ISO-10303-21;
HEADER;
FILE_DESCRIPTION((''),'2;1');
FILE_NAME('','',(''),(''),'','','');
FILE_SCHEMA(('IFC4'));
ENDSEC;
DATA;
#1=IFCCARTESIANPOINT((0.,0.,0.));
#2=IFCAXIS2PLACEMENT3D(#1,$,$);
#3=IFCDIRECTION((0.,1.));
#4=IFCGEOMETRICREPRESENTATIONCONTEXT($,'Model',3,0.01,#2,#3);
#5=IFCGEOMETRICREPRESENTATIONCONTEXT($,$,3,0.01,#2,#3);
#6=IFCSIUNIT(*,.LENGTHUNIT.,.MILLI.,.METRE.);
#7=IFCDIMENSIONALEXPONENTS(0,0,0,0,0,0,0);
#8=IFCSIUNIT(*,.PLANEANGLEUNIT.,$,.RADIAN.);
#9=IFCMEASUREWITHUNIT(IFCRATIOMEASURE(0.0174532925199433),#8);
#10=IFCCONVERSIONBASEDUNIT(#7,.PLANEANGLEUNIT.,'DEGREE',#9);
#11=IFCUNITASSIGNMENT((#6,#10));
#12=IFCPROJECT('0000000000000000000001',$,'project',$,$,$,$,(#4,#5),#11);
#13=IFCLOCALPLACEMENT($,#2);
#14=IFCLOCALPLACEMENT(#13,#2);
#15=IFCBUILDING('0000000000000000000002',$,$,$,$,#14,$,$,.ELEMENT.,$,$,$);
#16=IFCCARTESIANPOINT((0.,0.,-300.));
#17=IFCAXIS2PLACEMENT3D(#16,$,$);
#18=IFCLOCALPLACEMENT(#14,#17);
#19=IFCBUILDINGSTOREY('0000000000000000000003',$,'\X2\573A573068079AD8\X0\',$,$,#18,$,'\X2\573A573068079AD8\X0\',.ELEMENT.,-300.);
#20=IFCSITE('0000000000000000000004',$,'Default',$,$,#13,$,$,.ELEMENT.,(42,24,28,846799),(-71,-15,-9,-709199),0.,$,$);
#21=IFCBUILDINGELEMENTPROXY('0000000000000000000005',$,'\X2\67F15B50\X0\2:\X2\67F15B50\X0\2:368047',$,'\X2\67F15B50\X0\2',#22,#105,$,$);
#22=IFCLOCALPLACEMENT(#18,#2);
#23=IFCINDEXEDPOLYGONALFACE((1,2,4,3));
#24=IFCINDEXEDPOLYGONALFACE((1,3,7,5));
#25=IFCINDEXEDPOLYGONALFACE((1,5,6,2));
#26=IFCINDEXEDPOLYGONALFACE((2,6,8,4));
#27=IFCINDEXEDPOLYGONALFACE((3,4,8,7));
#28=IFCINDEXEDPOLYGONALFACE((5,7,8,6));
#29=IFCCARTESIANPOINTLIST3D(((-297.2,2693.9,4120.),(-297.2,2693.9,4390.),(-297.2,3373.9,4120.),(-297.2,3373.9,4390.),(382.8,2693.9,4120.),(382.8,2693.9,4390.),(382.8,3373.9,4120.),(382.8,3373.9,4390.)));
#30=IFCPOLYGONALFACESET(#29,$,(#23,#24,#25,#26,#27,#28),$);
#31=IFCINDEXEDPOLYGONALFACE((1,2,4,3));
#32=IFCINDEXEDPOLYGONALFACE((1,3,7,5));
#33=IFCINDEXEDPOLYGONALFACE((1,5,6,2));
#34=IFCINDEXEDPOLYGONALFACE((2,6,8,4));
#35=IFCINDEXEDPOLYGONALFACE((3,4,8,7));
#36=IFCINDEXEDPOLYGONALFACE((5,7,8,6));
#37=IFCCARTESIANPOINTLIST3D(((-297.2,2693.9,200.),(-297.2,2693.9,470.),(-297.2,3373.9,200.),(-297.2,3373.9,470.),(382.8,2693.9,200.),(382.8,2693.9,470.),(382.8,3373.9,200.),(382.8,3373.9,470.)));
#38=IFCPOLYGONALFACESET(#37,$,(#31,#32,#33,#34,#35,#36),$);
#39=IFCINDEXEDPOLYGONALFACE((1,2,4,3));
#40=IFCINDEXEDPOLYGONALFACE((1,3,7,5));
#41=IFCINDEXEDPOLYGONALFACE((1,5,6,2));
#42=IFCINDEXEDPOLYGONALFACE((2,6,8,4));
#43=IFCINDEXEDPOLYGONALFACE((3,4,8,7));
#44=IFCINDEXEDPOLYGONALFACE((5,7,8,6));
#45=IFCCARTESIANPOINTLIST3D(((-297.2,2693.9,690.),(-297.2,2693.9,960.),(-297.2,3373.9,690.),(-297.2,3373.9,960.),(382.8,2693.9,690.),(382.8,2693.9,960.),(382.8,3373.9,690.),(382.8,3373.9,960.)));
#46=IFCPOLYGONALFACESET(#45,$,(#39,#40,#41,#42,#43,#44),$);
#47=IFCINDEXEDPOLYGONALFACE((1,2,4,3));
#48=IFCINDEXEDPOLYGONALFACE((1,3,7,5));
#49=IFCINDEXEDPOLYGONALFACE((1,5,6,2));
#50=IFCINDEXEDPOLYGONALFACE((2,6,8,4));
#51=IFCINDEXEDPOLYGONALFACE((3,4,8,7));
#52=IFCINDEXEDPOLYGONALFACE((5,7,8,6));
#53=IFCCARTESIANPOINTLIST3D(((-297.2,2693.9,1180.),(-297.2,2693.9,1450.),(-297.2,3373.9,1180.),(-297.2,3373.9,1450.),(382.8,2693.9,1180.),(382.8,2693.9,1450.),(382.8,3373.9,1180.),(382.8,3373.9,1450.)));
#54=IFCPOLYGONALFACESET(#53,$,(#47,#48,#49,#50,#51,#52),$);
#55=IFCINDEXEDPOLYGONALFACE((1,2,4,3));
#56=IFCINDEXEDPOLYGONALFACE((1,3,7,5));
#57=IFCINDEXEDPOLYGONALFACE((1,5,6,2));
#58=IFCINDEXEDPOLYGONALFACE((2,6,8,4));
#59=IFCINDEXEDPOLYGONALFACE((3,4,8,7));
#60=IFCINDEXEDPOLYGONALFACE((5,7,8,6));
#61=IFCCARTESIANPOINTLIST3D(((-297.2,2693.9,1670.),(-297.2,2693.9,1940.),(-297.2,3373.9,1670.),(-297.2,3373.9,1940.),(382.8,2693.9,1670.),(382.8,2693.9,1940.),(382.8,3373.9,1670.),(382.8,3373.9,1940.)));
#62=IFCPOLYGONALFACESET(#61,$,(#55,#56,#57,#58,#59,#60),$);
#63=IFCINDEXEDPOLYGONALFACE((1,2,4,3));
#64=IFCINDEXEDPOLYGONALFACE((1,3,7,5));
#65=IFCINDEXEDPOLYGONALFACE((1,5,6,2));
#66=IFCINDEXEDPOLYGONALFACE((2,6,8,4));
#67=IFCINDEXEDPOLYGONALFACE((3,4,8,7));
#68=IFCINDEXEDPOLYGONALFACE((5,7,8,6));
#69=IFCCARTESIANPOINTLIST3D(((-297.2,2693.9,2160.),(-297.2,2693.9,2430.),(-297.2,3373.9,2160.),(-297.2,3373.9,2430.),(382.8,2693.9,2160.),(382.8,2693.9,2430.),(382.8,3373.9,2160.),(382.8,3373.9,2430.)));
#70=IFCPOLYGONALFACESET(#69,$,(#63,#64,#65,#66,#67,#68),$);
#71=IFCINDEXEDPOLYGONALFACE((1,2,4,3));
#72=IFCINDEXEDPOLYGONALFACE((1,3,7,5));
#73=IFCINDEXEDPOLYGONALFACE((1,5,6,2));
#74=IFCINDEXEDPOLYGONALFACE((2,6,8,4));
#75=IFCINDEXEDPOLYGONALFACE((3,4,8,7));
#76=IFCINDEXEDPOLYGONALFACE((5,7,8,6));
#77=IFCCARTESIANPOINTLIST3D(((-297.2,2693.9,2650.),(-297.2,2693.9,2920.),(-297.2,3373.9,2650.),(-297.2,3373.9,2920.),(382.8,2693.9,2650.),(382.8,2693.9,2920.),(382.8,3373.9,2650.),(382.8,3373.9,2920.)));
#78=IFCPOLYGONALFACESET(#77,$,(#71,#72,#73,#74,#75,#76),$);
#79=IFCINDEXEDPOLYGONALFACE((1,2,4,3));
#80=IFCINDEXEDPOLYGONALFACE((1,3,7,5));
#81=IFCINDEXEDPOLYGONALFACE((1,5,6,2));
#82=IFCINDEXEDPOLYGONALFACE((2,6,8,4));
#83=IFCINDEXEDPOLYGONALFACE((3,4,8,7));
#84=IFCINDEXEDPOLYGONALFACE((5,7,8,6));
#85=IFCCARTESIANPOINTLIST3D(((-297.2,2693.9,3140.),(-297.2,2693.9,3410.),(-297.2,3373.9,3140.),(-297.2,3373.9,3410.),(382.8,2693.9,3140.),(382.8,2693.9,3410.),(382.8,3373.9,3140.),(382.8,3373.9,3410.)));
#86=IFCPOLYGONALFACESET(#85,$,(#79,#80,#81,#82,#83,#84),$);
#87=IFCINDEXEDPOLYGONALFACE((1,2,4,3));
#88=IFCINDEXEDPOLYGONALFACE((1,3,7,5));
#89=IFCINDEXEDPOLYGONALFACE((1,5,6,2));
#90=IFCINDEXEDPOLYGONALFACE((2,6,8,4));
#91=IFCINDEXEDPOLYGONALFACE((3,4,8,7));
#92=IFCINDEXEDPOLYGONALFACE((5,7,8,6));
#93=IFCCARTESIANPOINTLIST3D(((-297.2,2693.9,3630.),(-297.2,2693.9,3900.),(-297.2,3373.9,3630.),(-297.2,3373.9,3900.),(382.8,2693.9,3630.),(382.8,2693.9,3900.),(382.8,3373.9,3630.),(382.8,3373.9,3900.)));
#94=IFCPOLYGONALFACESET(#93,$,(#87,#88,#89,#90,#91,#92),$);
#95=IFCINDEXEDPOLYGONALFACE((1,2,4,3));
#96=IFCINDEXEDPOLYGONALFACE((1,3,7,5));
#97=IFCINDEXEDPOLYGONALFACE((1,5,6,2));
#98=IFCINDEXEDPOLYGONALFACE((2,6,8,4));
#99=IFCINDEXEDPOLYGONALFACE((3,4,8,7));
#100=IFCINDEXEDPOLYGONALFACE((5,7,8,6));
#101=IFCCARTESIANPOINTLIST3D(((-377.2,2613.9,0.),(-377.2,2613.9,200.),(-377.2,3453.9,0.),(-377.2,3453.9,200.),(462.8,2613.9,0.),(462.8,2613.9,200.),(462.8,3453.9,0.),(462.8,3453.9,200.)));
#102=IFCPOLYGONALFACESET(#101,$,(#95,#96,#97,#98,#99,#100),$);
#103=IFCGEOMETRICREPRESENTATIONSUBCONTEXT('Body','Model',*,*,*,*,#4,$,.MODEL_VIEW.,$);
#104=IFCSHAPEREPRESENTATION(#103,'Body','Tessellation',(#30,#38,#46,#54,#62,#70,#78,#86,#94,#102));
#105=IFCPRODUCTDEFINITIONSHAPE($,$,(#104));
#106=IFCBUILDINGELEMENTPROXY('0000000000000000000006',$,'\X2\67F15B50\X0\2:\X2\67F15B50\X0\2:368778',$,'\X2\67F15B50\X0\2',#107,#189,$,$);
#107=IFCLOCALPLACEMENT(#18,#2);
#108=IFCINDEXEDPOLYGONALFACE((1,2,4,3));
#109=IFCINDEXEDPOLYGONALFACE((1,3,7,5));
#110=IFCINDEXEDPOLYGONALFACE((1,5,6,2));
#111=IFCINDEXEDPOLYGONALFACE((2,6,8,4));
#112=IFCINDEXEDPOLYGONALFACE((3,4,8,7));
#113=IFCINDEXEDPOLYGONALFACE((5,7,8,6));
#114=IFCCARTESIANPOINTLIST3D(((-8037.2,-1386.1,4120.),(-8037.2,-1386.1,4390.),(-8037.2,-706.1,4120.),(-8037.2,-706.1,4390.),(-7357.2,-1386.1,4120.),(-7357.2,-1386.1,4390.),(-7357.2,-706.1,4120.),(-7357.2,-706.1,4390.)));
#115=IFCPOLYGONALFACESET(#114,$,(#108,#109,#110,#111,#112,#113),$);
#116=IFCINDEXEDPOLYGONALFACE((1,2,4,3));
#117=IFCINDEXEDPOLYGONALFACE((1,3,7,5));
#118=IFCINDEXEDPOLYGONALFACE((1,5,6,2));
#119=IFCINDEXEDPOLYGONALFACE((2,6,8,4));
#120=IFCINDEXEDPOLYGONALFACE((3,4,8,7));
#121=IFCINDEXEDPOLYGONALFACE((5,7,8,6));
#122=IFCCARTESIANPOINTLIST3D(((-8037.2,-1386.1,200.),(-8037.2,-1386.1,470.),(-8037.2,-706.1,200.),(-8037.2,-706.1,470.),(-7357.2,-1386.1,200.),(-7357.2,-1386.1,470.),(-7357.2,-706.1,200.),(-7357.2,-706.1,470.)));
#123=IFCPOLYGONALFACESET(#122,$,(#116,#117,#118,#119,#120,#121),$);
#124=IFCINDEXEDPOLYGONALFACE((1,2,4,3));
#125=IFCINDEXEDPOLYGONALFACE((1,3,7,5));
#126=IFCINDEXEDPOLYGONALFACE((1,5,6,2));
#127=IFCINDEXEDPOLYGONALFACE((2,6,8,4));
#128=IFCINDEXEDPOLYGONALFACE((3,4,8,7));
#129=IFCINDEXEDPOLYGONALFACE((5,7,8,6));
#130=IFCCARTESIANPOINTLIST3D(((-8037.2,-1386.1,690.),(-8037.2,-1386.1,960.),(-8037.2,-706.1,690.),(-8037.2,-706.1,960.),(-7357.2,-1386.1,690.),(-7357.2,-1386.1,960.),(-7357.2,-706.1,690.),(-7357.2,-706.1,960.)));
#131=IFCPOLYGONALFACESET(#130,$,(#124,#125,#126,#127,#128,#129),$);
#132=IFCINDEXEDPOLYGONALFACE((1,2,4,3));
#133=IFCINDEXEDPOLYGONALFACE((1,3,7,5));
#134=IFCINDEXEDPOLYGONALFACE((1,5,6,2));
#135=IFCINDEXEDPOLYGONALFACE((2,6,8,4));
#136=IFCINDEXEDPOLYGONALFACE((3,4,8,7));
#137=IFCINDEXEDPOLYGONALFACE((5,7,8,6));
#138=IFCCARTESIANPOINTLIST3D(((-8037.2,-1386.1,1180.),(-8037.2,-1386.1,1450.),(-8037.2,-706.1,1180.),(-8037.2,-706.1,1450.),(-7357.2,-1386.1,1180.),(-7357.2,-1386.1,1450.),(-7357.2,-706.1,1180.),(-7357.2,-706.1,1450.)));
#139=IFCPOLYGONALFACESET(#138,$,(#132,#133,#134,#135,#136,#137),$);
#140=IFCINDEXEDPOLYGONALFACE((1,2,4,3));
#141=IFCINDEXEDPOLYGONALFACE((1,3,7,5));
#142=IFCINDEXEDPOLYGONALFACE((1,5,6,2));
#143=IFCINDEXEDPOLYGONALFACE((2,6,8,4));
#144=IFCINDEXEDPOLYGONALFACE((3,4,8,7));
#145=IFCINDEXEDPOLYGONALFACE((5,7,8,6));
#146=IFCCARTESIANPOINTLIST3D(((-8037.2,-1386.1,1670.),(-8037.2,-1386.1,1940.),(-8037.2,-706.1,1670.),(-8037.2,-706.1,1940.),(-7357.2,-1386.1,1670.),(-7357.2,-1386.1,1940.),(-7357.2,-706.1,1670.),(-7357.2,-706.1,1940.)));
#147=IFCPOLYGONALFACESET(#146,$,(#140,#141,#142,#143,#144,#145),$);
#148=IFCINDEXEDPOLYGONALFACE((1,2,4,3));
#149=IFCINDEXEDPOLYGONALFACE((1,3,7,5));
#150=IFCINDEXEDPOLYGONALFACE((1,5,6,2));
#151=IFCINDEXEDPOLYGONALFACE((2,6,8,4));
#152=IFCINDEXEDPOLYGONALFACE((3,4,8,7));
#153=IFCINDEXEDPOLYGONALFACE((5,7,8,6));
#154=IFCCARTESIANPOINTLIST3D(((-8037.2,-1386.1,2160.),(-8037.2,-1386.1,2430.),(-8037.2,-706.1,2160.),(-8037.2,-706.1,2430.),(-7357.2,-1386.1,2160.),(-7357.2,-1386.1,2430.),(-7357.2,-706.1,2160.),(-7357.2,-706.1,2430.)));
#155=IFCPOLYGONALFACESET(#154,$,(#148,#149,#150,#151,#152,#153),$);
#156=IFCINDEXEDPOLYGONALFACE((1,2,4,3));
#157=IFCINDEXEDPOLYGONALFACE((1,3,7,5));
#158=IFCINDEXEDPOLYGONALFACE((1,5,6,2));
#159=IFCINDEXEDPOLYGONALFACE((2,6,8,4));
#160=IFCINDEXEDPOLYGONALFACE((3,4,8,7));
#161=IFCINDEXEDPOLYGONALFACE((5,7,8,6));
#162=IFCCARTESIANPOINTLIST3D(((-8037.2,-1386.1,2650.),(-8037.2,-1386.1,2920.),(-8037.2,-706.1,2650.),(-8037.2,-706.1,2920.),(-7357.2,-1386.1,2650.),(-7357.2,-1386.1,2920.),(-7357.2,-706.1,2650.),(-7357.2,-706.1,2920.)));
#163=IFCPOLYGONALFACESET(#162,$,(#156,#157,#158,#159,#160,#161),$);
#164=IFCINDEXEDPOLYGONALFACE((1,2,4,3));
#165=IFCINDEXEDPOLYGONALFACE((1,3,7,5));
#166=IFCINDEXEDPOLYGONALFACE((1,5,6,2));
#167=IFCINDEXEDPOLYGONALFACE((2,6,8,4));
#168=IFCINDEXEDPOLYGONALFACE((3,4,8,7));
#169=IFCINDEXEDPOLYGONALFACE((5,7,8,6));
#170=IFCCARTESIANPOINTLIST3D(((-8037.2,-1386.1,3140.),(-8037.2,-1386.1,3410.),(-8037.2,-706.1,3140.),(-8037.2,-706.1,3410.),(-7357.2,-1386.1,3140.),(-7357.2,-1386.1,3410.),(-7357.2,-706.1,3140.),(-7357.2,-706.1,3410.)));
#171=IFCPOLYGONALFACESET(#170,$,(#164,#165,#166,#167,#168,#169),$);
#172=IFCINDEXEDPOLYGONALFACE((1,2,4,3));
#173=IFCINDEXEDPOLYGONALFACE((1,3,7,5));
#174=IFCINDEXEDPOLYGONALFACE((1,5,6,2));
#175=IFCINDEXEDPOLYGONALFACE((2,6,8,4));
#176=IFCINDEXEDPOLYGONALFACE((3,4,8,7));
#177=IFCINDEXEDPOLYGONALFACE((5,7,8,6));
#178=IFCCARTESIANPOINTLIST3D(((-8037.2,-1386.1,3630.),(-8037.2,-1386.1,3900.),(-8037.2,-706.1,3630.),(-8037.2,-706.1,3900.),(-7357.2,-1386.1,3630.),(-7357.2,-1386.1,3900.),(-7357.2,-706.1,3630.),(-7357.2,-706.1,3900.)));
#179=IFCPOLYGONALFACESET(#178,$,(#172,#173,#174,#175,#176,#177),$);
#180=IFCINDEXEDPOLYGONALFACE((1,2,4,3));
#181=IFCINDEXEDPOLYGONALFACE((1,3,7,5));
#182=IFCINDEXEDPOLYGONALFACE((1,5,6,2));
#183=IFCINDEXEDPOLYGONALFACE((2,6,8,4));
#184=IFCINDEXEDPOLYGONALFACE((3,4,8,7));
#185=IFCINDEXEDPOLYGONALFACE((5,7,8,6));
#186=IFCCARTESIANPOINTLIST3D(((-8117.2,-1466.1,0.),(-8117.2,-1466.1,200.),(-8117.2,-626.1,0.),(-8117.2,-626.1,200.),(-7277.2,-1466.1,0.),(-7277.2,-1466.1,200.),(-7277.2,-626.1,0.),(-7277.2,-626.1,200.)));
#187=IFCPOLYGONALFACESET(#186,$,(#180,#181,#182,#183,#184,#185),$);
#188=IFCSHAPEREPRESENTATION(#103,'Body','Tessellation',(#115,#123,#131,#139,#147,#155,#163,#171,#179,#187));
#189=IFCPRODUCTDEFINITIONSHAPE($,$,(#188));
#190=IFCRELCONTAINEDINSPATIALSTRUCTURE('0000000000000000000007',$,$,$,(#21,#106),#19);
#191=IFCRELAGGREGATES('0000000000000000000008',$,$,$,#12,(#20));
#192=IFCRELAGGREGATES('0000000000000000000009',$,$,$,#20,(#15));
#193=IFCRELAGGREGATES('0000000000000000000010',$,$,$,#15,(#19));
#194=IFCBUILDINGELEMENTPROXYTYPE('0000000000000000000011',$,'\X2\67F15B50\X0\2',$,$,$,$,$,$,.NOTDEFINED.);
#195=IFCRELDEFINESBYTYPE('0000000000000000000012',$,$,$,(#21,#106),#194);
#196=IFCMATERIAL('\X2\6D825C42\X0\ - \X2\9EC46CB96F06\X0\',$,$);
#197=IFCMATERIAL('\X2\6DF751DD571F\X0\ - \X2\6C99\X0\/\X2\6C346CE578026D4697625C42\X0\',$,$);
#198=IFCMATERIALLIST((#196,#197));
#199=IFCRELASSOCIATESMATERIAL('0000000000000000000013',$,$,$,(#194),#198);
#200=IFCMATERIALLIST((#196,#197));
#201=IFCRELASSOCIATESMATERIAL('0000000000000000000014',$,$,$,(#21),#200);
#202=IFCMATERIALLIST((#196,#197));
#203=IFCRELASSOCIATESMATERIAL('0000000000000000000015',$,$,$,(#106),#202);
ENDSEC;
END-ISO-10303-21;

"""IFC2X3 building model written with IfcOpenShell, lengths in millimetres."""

from ifc_helpers import new_model, entity, si_unit, converted_unit, direction, frame, origin, origin_2d_with_axis, place, context, subcontext, project, spatial, rectangle, extrude, source, transform, mapped, material, material_list, type_object, type_shapes, element, save


model = new_model("IFC2X3")

# Units and contexts
model_context = context("Model", 3, precision=0.01, world=origin(), true_north=direction((0.0, 1.0)))
context_of_model = context(None, 3, precision=0.01, world=origin(), true_north=direction((0.0, 1.0)))
body_context = subcontext(model_context, "Body", "Model", "MODEL_VIEW")
ifc_project = project(units=[si_unit("LENGTHUNIT", "METRE", prefix="MILLI"), converted_unit("PLANEANGLEUNIT", "DEGREE", entity("IfcRatioMeasure", 0.0174532925199433), si_unit("PLANEANGLEUNIT", "RADIAN"), dimensions=[0, 0, 0, 0, 0, 0, 0])], contexts=[model_context, context_of_model])

# Site, building, storey
site_placement = place(None, origin())
site = spatial("IfcSite", under=ifc_project, at=site_placement, Name="Default", CompositionType="ELEMENT", RefLatitude=(42, 24, 28, 846799), RefLongitude=(-71, -15, -9, -709199), RefElevation=0.0)
building_placement = place(site_placement, origin())
building = spatial("IfcBuilding", under=site, at=building_placement, CompositionType="ELEMENT")
storey_placement = place(building_placement, frame((0.0, 0.0, -300.0)))
storey = spatial("IfcBuildingStorey", under=building, at=storey_placement, Name="场地标高", LongName="场地标高", CompositionType="ELEMENT", Elevation=-300.0)

# Shared definitions
ifc_material_1 = material(Name="混凝土 - 沙/水泥砂浆面层")

# Building element proxies
ifc_material_2 = material(Name="涂层 - 黄油漆")
ifc_material_list_1 = material_list([ifc_material_2, ifc_material_1])
building_element_proxy_type_1 = type_object("IfcBuildingElementProxyType", Name="柱子2", PredefinedType="NOTDEFINED", material=ifc_material_list_1)
shared_shape_1 = source(origin(), body_context, "Body", "SweptSolid", [
    extrude(rectangle(XDim=680.0, YDim=680.0, at=origin_2d_with_axis()), frame((0.0, 0.0, 4120.0), z_axis=(0.0, 0.0, 1.0), x_axis=(0.0, 1.0, 0.0)), (0.0, 0.0, 1.0), 270.0),
    extrude(rectangle(XDim=680.0, YDim=680.0, at=origin_2d_with_axis()), frame((0.0, 0.0, 200.0), z_axis=(0.0, 0.0, 1.0), x_axis=(0.0, 1.0, 0.0)), (0.0, 0.0, 1.0), 270.0),
    extrude(rectangle(XDim=680.0, YDim=680.0, at=origin_2d_with_axis()), frame((0.0, 0.0, 690.0), z_axis=(0.0, 0.0, 1.0), x_axis=(0.0, 1.0, 0.0)), (0.0, 0.0, 1.0), 270.0),
    extrude(rectangle(XDim=680.0, YDim=680.0, at=origin_2d_with_axis()), frame((0.0, 0.0, 1180.0), z_axis=(0.0, 0.0, 1.0), x_axis=(0.0, 1.0, 0.0)), (0.0, 0.0, 1.0), 270.0),
    extrude(rectangle(XDim=680.0, YDim=680.0, at=origin_2d_with_axis()), frame((0.0, 0.0, 1670.0), z_axis=(0.0, 0.0, 1.0), x_axis=(0.0, 1.0, 0.0)), (0.0, 0.0, 1.0), 270.0),
    extrude(rectangle(XDim=680.0, YDim=680.0, at=origin_2d_with_axis()), frame((0.0, 0.0, 2160.0), z_axis=(0.0, 0.0, 1.0), x_axis=(0.0, 1.0, 0.0)), (0.0, 0.0, 1.0), 270.0),
    extrude(rectangle(XDim=680.0, YDim=680.0, at=origin_2d_with_axis()), frame((0.0, 0.0, 2650.0), z_axis=(0.0, 0.0, 1.0), x_axis=(0.0, 1.0, 0.0)), (0.0, 0.0, 1.0), 270.0),
    extrude(rectangle(XDim=680.0, YDim=680.0, at=origin_2d_with_axis()), frame((0.0, 0.0, 3140.0), z_axis=(0.0, 0.0, 1.0), x_axis=(0.0, 1.0, 0.0)), (0.0, 0.0, 1.0), 270.0),
    extrude(rectangle(XDim=680.0, YDim=680.0, at=origin_2d_with_axis()), frame((0.0, 0.0, 3630.0), z_axis=(0.0, 0.0, 1.0), x_axis=(0.0, 1.0, 0.0)), (0.0, 0.0, 1.0), 270.0),
    extrude(rectangle(XDim=840.0, YDim=840.0, at=origin_2d_with_axis()), frame((0.0, 0.0, 0.0), z_axis=(0.0, 0.0, 1.0), x_axis=(0.0, 1.0, 0.0)), (0.0, 0.0, 1.0), 200.0),
])
type_shapes(building_element_proxy_type_1, [shared_shape_1])
ifc_material_list_2 = material_list([ifc_material_2, ifc_material_1])
proxy_1_placement = place(storey_placement, frame((42.8, 3033.9, 0.0)))
element("IfcBuildingElementProxy", 1, at=proxy_1_placement, inside=storey, type_object=building_element_proxy_type_1, material=ifc_material_list_2, Name="柱子2:柱子2:368047", ObjectType="柱子2", context=body_context, shape_type="MappedRepresentation", body=[
    mapped(shared_shape_1, transform((0.0, 0.0, 0.0), scale=1.0)),
])
ifc_material_list_3 = material_list([ifc_material_2, ifc_material_1])
proxy_2_placement = place(storey_placement, frame((-7697.2, -1046.1, 0.0)))
element("IfcBuildingElementProxy", 2, at=proxy_2_placement, inside=storey, type_object=building_element_proxy_type_1, material=ifc_material_list_3, Name="柱子2:柱子2:368778", ObjectType="柱子2", context=body_context, shape_type="MappedRepresentation", body=[
    mapped(shared_shape_1, transform((0.0, 0.0, 0.0), scale=1.0)),
])

save(model, "model.ifc")
